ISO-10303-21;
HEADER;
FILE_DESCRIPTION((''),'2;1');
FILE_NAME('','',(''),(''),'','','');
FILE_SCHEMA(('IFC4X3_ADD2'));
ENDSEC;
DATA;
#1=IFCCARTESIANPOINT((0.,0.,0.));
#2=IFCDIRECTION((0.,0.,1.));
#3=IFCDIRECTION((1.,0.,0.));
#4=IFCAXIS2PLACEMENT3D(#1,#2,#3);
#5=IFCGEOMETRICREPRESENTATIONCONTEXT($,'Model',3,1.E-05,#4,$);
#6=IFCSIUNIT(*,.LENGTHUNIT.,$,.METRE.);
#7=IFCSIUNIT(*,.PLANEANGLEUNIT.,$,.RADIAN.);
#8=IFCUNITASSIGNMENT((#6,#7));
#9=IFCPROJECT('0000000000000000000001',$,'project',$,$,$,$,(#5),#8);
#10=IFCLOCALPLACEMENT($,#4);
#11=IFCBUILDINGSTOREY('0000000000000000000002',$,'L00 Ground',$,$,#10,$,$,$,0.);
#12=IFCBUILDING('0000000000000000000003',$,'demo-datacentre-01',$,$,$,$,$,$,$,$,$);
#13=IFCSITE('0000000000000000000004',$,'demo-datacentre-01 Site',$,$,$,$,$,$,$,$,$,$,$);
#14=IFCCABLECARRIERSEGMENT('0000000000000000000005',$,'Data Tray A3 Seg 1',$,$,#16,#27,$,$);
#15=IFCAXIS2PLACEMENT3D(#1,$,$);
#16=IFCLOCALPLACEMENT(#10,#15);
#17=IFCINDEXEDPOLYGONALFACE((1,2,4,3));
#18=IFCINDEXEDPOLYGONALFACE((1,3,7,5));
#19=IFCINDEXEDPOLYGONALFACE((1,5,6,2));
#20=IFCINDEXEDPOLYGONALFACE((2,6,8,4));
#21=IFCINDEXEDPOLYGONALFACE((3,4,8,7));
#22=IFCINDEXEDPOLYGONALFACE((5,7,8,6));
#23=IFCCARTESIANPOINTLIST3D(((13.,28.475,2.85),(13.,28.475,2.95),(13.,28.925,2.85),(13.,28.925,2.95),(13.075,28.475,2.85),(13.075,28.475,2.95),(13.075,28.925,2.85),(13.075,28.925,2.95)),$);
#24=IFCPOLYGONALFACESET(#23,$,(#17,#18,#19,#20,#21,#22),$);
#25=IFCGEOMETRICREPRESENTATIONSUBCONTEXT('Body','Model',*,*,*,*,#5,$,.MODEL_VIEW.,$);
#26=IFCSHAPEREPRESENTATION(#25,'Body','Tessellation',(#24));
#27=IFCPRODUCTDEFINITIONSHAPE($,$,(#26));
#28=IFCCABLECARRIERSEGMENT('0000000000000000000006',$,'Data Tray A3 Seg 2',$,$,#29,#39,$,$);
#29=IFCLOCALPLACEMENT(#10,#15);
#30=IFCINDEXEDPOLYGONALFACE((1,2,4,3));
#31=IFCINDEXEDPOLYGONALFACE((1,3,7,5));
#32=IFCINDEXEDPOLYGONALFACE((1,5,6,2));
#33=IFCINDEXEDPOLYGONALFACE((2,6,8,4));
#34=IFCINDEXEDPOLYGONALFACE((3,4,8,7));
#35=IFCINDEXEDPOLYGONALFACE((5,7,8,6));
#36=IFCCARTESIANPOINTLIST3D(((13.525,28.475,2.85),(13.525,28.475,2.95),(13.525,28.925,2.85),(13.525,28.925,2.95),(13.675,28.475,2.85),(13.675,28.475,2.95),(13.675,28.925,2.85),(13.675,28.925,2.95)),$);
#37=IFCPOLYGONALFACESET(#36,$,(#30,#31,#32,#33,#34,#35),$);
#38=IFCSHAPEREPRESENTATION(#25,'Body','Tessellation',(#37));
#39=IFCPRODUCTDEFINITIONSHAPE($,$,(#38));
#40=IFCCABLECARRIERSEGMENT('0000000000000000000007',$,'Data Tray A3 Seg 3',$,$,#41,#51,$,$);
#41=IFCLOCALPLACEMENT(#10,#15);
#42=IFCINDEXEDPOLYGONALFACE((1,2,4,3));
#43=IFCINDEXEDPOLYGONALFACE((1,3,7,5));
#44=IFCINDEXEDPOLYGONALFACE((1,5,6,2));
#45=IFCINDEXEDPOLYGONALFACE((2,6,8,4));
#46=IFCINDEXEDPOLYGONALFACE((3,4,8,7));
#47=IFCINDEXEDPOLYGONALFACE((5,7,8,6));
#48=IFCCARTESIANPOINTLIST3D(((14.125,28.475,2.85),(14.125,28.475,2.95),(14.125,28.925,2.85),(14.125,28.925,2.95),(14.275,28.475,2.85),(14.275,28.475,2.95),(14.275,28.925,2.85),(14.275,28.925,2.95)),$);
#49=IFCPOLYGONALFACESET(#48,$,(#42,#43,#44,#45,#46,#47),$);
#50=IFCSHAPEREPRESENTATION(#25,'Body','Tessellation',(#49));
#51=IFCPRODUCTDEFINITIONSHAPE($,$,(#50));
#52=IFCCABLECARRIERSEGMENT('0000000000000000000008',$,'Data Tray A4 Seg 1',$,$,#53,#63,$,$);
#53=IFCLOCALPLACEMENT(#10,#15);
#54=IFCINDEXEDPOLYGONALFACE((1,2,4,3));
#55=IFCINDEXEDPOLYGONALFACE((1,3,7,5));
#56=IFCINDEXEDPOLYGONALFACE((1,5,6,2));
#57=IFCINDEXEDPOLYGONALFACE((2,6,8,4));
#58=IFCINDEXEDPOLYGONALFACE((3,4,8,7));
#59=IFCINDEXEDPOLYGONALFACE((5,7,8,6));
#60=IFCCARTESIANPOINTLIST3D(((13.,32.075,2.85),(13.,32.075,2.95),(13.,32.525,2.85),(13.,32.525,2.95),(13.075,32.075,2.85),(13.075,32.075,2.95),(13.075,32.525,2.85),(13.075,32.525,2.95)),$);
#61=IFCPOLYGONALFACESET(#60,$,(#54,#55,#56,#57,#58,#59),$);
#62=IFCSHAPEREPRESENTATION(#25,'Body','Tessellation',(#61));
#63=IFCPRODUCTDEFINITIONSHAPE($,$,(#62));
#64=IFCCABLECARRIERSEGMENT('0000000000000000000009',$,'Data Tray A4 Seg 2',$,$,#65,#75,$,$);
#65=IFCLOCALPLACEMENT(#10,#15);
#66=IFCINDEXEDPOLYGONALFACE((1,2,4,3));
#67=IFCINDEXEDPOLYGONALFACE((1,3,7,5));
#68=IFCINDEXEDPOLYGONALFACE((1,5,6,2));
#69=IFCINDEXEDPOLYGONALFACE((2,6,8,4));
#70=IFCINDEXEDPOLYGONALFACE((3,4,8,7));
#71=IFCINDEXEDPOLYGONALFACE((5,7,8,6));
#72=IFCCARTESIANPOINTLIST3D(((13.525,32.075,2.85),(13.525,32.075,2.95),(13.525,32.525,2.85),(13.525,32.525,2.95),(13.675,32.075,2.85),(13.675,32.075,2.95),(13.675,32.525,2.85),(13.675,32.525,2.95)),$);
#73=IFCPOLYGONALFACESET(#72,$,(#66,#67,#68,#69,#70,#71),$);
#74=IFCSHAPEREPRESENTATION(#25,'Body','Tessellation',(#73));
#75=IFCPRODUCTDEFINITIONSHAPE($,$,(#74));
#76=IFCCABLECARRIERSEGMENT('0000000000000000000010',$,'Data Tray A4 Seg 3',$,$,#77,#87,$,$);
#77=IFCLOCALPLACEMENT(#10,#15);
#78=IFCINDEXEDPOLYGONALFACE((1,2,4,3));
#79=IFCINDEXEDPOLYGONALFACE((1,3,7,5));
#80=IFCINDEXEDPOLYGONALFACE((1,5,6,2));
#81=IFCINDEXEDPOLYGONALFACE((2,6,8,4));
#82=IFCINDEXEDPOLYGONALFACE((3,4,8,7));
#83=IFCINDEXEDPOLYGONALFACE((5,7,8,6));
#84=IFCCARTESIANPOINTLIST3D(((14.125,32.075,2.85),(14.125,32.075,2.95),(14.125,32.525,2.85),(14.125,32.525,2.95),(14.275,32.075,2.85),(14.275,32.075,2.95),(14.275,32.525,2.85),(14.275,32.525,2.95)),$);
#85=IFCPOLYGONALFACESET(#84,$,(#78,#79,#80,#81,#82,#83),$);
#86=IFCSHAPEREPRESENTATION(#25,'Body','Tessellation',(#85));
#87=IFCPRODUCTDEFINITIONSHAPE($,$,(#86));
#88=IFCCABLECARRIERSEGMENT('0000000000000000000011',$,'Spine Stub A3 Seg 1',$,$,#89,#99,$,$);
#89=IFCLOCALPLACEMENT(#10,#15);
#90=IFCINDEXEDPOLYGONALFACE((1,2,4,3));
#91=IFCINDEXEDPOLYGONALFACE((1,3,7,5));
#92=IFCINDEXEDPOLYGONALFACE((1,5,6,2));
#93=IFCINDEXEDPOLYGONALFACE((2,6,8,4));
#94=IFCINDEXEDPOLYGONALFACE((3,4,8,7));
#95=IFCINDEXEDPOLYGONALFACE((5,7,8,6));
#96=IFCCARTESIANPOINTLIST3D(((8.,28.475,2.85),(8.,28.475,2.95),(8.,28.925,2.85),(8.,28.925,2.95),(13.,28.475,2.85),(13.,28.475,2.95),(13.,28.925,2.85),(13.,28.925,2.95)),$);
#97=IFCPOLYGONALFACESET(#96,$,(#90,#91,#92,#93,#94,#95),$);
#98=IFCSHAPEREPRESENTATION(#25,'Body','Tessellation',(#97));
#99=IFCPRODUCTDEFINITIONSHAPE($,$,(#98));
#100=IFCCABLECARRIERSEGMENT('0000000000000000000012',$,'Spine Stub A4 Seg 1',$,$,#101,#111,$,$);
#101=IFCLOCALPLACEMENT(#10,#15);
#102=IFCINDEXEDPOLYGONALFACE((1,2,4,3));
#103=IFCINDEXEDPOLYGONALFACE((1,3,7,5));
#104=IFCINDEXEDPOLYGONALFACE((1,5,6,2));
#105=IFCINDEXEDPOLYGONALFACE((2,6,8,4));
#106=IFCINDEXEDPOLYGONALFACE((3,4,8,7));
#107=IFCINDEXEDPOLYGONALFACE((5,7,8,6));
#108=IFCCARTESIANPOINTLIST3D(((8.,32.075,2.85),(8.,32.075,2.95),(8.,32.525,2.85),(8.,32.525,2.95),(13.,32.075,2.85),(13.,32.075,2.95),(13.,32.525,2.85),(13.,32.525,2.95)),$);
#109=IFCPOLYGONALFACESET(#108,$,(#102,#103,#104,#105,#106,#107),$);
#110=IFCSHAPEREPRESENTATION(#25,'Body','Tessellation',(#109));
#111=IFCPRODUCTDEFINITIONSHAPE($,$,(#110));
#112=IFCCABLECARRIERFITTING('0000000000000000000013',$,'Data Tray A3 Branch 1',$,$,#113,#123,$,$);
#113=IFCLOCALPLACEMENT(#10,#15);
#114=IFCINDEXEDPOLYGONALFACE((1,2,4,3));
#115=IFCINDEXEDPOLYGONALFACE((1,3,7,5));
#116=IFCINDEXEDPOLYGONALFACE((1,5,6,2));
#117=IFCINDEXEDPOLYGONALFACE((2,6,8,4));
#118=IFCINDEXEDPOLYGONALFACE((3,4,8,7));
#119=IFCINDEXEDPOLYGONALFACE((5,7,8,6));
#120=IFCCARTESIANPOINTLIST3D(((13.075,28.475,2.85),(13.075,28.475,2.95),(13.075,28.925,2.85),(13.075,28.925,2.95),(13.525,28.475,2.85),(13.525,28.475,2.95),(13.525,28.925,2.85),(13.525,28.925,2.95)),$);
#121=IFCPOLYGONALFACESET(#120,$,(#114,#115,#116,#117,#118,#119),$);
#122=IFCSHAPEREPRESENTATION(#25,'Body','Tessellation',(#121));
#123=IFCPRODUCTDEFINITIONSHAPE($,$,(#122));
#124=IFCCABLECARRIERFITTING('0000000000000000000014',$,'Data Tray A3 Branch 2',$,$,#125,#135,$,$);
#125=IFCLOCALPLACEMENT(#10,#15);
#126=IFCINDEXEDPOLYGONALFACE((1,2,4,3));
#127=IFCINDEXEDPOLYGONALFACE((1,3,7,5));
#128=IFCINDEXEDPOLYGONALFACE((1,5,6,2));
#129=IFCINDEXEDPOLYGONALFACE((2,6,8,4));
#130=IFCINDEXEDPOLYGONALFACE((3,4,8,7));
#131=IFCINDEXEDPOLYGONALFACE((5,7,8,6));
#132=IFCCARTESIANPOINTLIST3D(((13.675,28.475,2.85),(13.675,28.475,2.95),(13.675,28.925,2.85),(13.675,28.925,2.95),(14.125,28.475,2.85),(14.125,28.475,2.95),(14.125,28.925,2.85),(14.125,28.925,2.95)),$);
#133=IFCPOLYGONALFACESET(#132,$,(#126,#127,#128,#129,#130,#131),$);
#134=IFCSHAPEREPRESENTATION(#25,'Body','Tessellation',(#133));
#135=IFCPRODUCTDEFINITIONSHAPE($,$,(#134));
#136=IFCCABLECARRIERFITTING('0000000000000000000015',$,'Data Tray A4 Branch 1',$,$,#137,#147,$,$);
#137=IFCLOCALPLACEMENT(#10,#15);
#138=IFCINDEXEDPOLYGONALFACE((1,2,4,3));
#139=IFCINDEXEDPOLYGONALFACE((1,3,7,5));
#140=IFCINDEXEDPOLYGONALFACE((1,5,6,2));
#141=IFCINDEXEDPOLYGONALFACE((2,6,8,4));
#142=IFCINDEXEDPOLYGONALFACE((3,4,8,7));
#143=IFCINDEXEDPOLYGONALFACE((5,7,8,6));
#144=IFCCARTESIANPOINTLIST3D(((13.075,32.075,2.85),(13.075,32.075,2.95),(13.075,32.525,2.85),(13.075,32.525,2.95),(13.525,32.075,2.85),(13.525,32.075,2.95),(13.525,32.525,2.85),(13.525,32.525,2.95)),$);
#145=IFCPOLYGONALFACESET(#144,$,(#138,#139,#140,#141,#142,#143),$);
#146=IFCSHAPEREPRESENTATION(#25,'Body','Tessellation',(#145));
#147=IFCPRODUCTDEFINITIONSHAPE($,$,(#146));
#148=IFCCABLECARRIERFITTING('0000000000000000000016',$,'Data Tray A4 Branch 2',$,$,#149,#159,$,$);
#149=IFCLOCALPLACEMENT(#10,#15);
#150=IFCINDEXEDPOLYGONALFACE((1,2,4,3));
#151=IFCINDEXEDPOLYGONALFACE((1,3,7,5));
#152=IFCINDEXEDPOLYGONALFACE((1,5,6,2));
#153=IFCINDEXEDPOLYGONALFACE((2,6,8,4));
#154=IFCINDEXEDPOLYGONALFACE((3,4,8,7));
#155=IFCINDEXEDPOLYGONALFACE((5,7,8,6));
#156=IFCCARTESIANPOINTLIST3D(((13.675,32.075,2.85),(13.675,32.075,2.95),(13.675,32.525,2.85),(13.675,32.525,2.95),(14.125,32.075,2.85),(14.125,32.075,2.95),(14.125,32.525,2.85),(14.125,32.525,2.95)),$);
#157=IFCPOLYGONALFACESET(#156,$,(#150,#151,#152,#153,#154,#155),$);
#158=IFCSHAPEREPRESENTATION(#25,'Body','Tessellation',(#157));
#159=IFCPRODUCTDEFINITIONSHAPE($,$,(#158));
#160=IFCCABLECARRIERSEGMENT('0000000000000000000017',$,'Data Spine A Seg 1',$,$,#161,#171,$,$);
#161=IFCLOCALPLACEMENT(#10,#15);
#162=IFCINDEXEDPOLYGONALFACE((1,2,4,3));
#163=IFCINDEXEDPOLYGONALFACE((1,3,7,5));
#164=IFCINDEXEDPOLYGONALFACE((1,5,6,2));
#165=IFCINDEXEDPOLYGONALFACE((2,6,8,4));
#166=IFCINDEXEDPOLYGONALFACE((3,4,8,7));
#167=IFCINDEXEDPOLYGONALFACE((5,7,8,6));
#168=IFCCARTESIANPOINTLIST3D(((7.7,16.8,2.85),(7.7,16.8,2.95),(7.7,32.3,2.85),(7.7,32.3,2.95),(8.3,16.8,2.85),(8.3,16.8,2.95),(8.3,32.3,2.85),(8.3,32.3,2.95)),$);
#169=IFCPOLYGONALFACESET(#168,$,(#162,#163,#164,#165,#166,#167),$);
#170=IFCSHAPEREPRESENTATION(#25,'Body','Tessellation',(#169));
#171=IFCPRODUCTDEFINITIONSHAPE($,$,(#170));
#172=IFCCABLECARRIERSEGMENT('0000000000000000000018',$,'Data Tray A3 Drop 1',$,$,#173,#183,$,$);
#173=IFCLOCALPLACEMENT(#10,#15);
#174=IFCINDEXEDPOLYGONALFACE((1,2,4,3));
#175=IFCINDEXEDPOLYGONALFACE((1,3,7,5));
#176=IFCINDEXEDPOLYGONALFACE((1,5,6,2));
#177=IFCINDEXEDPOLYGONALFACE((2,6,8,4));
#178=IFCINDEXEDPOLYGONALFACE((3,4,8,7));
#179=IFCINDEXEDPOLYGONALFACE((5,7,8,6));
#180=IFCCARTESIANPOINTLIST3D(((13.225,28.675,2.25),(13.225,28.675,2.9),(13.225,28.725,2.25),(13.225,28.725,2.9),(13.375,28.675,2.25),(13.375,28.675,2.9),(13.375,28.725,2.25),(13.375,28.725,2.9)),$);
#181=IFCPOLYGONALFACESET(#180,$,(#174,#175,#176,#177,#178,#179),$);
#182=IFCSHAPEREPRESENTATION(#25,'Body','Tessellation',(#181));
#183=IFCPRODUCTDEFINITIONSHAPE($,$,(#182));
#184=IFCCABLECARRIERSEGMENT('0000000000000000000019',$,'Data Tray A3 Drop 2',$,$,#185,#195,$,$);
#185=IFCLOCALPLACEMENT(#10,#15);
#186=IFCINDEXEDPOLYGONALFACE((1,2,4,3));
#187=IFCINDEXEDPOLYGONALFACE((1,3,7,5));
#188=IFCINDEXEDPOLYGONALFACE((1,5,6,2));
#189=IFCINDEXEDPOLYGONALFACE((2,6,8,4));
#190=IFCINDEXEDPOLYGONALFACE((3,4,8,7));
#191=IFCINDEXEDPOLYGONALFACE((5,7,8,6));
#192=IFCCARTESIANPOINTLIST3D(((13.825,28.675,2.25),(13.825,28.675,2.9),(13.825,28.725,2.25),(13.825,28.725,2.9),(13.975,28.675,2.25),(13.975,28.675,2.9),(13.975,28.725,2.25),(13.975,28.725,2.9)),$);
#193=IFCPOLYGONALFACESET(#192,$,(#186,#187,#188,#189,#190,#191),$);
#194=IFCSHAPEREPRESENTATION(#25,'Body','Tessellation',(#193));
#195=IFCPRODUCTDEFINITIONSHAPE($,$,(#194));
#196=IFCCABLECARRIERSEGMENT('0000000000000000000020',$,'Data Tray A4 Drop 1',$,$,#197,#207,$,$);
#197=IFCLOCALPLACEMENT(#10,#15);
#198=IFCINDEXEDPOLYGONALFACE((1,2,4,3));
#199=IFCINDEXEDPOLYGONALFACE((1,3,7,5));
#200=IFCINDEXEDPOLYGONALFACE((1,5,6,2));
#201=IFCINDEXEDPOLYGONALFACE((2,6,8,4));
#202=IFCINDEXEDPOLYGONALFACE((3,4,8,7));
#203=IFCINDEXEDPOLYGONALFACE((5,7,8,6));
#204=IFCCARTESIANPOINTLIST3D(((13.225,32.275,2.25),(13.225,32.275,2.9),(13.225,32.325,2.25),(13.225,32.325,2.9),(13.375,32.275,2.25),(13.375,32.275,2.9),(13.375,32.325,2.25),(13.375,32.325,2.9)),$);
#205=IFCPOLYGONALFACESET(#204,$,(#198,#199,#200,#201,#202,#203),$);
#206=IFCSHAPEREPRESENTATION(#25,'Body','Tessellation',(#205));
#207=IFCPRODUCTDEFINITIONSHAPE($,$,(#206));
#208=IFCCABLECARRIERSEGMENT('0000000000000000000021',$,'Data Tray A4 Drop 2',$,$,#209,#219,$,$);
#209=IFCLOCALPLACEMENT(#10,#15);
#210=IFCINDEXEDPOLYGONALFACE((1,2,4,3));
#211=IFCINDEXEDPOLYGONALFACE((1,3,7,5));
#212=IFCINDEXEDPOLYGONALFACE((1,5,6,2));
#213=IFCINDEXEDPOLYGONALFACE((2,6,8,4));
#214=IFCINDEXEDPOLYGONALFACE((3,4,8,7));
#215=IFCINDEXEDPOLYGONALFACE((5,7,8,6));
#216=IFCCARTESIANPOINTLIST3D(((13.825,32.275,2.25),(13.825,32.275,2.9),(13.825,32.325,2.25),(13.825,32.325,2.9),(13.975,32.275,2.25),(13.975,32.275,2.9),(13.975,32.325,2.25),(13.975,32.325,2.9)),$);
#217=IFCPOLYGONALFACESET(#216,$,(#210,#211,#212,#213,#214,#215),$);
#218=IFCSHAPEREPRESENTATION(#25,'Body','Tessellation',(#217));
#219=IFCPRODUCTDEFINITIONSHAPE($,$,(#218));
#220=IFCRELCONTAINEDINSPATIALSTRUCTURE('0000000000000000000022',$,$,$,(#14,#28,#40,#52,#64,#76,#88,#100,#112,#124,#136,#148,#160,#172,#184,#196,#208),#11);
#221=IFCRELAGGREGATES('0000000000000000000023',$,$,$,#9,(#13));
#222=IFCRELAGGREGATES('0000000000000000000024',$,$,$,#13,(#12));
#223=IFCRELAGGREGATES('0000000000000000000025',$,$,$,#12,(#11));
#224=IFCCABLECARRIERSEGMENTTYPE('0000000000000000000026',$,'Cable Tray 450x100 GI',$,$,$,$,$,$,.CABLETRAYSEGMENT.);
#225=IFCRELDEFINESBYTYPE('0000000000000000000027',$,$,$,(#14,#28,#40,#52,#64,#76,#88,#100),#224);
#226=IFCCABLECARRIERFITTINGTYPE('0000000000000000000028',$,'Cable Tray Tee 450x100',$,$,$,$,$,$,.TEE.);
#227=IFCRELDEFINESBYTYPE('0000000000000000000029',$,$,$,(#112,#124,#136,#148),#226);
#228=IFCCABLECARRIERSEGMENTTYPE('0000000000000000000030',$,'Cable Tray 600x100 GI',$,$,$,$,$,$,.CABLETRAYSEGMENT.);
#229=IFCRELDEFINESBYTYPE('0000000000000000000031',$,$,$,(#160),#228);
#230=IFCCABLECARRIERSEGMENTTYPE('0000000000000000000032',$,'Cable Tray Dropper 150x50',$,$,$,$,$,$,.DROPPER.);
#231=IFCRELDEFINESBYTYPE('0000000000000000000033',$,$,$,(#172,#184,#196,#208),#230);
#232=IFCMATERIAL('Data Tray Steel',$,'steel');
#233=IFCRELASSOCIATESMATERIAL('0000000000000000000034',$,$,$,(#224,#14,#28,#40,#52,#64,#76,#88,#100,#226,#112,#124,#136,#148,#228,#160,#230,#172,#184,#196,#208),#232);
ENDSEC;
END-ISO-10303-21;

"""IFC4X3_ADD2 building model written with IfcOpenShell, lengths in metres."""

from ifc_helpers import new_model, si_unit, frame, origin_with_axes, place, context, subcontext, project, spatial, rectangle, extrude, material, type_object, element, save


model = new_model("IFC4X3_ADD2")

# Units and contexts
model_context = context("Model", 3, precision=1e-05, world=origin_with_axes())
body_context = subcontext(model_context, "Body", "Model", "MODEL_VIEW")
ifc_project = project(units=[si_unit("LENGTHUNIT", "METRE"), si_unit("PLANEANGLEUNIT", "RADIAN")], contexts=[model_context])

# Site, building, storey
site = spatial("IfcSite", under=ifc_project, Name="demo-datacentre-01 Site")
building = spatial("IfcBuilding", under=site, Name="demo-datacentre-01")
storey_placement = place(None, origin_with_axes())
storey = spatial("IfcBuildingStorey", under=building, at=storey_placement, Name="L00 Ground", Elevation=0.0)

# Cable carrier segments
ifc_material_1 = material(Name="Data Tray Steel", Category="steel")
cable_carrier_segment_type_1 = type_object("IfcCableCarrierSegmentType", Name="Cable Tray 450x100 GI", PredefinedType="CABLETRAYSEGMENT", material=ifc_material_1)
cable_carrier_segment_1_placement = place(storey_placement, frame((13.0, 28.7, 2.9), z_axis=(1.0, 0.0, 0.0), x_axis=(0.0, 1.0, 0.0)))
element("IfcCableCarrierSegment", 1, at=cable_carrier_segment_1_placement, inside=storey, type_object=cable_carrier_segment_type_1, material=ifc_material_1, Name="Data Tray A3 Seg 1", context=body_context, shape_type="SweptSolid", body=[
    extrude(rectangle(XDim=0.45, YDim=0.1), origin_with_axes(), (0.0, 0.0, 1.0), 0.075),
])
for number, where, z_axis, x_axis, name in (
    (2, (13.525, 28.7, 2.9), (1.0, 0.0, 0.0), (0.0, 1.0, 0.0), "Data Tray A3 Seg 2"),
    (3, (14.125, 28.7, 2.9), (1.0, 0.0, 0.0), (0.0, 1.0, 0.0), "Data Tray A3 Seg 3"),
):
    element("IfcCableCarrierSegment", number, at=place(storey_placement, frame(where, z_axis=z_axis, x_axis=x_axis)), inside=storey, type_object=cable_carrier_segment_type_1, material=ifc_material_1, Name=name, context=body_context, shape_type="SweptSolid", body=[
        extrude(rectangle(XDim=0.45, YDim=0.1), origin_with_axes(), (0.0, 0.0, 1.0), 0.15),
    ])
cable_carrier_segment_2_placement = place(storey_placement, frame((13.0, 32.3, 2.9), z_axis=(1.0, 0.0, 0.0), x_axis=(0.0, 1.0, 0.0)))
element("IfcCableCarrierSegment", 4, at=cable_carrier_segment_2_placement, inside=storey, type_object=cable_carrier_segment_type_1, material=ifc_material_1, Name="Data Tray A4 Seg 1", context=body_context, shape_type="SweptSolid", body=[
    extrude(rectangle(XDim=0.45, YDim=0.1), origin_with_axes(), (0.0, 0.0, 1.0), 0.075),
])
for number, where, z_axis, x_axis, name in (
    (5, (13.525, 32.3, 2.9), (1.0, 0.0, 0.0), (0.0, 1.0, 0.0), "Data Tray A4 Seg 2"),
    (6, (14.125, 32.3, 2.9), (1.0, 0.0, 0.0), (0.0, 1.0, 0.0), "Data Tray A4 Seg 3"),
):
    element("IfcCableCarrierSegment", number, at=place(storey_placement, frame(where, z_axis=z_axis, x_axis=x_axis)), inside=storey, type_object=cable_carrier_segment_type_1, material=ifc_material_1, Name=name, context=body_context, shape_type="SweptSolid", body=[
        extrude(rectangle(XDim=0.45, YDim=0.1), origin_with_axes(), (0.0, 0.0, 1.0), 0.15),
    ])
for number, where, z_axis, x_axis, name in (
    (7, (8.0, 28.7, 2.9), (1.0, 0.0, 0.0), (0.0, 1.0, 0.0), "Spine Stub A3 Seg 1"),
    (8, (8.0, 32.3, 2.9), (1.0, 0.0, 0.0), (0.0, 1.0, 0.0), "Spine Stub A4 Seg 1"),
):
    element("IfcCableCarrierSegment", number, at=place(storey_placement, frame(where, z_axis=z_axis, x_axis=x_axis)), inside=storey, type_object=cable_carrier_segment_type_1, material=ifc_material_1, Name=name, context=body_context, shape_type="SweptSolid", body=[
        extrude(rectangle(XDim=0.45, YDim=0.1), origin_with_axes(), (0.0, 0.0, 1.0), 5.0),
    ])

# Cable carrier fittings
cable_carrier_fitting_type = type_object("IfcCableCarrierFittingType", Name="Cable Tray Tee 450x100", PredefinedType="TEE", material=ifc_material_1)
for number, where, z_axis, x_axis, name in (
    (9, (13.3, 28.7, 2.85), (0.0, 0.0, 1.0), (1.0, 0.0, 0.0), "Data Tray A3 Branch 1"),
    (10, (13.9, 28.7, 2.85), (0.0, 0.0, 1.0), (1.0, 0.0, 0.0), "Data Tray A3 Branch 2"),
    (11, (13.3, 32.3, 2.85), (0.0, 0.0, 1.0), (1.0, 0.0, 0.0), "Data Tray A4 Branch 1"),
    (12, (13.9, 32.3, 2.85), (0.0, 0.0, 1.0), (1.0, 0.0, 0.0), "Data Tray A4 Branch 2"),
):
    element("IfcCableCarrierFitting", number, at=place(storey_placement, frame(where, z_axis=z_axis, x_axis=x_axis)), inside=storey, type_object=cable_carrier_fitting_type, material=ifc_material_1, Name=name, context=body_context, shape_type="SweptSolid", body=[
        extrude(rectangle(XDim=0.45, YDim=0.45), origin_with_axes(), (0.0, 0.0, 1.0), 0.1),
    ])

# Cable carrier segments
cable_carrier_segment_type_2 = type_object("IfcCableCarrierSegmentType", Name="Cable Tray 600x100 GI", PredefinedType="CABLETRAYSEGMENT", material=ifc_material_1)
cable_carrier_segment_3_placement = place(storey_placement, frame((8.0, 32.3, 2.9), z_axis=(0.0, -1.0, 0.0), x_axis=(1.0, 0.0, 0.0)))
element("IfcCableCarrierSegment", 13, at=cable_carrier_segment_3_placement, inside=storey, type_object=cable_carrier_segment_type_2, material=ifc_material_1, Name="Data Spine A Seg 1", context=body_context, shape_type="SweptSolid", body=[
    extrude(rectangle(XDim=0.6, YDim=0.1), origin_with_axes(), (0.0, 0.0, 1.0), 15.5),
])
cable_carrier_segment_type_3 = type_object("IfcCableCarrierSegmentType", Name="Cable Tray Dropper 150x50", PredefinedType="DROPPER", material=ifc_material_1)
for number, where, z_axis, x_axis, name in (
    (14, (13.3, 28.7, 2.9), (0.0, 0.0, -1.0), (1.0, 0.0, 0.0), "Data Tray A3 Drop 1"),
    (15, (13.9, 28.7, 2.9), (0.0, 0.0, -1.0), (1.0, 0.0, 0.0), "Data Tray A3 Drop 2"),
    (16, (13.3, 32.3, 2.9), (0.0, 0.0, -1.0), (1.0, 0.0, 0.0), "Data Tray A4 Drop 1"),
    (17, (13.9, 32.3, 2.9), (0.0, 0.0, -1.0), (1.0, 0.0, 0.0), "Data Tray A4 Drop 2"),
):
    element("IfcCableCarrierSegment", number, at=place(storey_placement, frame(where, z_axis=z_axis, x_axis=x_axis)), inside=storey, type_object=cable_carrier_segment_type_3, material=ifc_material_1, Name=name, context=body_context, shape_type="SweptSolid", body=[
        extrude(rectangle(XDim=0.15, YDim=0.05), origin_with_axes(), (0.0, 0.0, 1.0), 0.65),
    ])

save(model, "model.ifc")
